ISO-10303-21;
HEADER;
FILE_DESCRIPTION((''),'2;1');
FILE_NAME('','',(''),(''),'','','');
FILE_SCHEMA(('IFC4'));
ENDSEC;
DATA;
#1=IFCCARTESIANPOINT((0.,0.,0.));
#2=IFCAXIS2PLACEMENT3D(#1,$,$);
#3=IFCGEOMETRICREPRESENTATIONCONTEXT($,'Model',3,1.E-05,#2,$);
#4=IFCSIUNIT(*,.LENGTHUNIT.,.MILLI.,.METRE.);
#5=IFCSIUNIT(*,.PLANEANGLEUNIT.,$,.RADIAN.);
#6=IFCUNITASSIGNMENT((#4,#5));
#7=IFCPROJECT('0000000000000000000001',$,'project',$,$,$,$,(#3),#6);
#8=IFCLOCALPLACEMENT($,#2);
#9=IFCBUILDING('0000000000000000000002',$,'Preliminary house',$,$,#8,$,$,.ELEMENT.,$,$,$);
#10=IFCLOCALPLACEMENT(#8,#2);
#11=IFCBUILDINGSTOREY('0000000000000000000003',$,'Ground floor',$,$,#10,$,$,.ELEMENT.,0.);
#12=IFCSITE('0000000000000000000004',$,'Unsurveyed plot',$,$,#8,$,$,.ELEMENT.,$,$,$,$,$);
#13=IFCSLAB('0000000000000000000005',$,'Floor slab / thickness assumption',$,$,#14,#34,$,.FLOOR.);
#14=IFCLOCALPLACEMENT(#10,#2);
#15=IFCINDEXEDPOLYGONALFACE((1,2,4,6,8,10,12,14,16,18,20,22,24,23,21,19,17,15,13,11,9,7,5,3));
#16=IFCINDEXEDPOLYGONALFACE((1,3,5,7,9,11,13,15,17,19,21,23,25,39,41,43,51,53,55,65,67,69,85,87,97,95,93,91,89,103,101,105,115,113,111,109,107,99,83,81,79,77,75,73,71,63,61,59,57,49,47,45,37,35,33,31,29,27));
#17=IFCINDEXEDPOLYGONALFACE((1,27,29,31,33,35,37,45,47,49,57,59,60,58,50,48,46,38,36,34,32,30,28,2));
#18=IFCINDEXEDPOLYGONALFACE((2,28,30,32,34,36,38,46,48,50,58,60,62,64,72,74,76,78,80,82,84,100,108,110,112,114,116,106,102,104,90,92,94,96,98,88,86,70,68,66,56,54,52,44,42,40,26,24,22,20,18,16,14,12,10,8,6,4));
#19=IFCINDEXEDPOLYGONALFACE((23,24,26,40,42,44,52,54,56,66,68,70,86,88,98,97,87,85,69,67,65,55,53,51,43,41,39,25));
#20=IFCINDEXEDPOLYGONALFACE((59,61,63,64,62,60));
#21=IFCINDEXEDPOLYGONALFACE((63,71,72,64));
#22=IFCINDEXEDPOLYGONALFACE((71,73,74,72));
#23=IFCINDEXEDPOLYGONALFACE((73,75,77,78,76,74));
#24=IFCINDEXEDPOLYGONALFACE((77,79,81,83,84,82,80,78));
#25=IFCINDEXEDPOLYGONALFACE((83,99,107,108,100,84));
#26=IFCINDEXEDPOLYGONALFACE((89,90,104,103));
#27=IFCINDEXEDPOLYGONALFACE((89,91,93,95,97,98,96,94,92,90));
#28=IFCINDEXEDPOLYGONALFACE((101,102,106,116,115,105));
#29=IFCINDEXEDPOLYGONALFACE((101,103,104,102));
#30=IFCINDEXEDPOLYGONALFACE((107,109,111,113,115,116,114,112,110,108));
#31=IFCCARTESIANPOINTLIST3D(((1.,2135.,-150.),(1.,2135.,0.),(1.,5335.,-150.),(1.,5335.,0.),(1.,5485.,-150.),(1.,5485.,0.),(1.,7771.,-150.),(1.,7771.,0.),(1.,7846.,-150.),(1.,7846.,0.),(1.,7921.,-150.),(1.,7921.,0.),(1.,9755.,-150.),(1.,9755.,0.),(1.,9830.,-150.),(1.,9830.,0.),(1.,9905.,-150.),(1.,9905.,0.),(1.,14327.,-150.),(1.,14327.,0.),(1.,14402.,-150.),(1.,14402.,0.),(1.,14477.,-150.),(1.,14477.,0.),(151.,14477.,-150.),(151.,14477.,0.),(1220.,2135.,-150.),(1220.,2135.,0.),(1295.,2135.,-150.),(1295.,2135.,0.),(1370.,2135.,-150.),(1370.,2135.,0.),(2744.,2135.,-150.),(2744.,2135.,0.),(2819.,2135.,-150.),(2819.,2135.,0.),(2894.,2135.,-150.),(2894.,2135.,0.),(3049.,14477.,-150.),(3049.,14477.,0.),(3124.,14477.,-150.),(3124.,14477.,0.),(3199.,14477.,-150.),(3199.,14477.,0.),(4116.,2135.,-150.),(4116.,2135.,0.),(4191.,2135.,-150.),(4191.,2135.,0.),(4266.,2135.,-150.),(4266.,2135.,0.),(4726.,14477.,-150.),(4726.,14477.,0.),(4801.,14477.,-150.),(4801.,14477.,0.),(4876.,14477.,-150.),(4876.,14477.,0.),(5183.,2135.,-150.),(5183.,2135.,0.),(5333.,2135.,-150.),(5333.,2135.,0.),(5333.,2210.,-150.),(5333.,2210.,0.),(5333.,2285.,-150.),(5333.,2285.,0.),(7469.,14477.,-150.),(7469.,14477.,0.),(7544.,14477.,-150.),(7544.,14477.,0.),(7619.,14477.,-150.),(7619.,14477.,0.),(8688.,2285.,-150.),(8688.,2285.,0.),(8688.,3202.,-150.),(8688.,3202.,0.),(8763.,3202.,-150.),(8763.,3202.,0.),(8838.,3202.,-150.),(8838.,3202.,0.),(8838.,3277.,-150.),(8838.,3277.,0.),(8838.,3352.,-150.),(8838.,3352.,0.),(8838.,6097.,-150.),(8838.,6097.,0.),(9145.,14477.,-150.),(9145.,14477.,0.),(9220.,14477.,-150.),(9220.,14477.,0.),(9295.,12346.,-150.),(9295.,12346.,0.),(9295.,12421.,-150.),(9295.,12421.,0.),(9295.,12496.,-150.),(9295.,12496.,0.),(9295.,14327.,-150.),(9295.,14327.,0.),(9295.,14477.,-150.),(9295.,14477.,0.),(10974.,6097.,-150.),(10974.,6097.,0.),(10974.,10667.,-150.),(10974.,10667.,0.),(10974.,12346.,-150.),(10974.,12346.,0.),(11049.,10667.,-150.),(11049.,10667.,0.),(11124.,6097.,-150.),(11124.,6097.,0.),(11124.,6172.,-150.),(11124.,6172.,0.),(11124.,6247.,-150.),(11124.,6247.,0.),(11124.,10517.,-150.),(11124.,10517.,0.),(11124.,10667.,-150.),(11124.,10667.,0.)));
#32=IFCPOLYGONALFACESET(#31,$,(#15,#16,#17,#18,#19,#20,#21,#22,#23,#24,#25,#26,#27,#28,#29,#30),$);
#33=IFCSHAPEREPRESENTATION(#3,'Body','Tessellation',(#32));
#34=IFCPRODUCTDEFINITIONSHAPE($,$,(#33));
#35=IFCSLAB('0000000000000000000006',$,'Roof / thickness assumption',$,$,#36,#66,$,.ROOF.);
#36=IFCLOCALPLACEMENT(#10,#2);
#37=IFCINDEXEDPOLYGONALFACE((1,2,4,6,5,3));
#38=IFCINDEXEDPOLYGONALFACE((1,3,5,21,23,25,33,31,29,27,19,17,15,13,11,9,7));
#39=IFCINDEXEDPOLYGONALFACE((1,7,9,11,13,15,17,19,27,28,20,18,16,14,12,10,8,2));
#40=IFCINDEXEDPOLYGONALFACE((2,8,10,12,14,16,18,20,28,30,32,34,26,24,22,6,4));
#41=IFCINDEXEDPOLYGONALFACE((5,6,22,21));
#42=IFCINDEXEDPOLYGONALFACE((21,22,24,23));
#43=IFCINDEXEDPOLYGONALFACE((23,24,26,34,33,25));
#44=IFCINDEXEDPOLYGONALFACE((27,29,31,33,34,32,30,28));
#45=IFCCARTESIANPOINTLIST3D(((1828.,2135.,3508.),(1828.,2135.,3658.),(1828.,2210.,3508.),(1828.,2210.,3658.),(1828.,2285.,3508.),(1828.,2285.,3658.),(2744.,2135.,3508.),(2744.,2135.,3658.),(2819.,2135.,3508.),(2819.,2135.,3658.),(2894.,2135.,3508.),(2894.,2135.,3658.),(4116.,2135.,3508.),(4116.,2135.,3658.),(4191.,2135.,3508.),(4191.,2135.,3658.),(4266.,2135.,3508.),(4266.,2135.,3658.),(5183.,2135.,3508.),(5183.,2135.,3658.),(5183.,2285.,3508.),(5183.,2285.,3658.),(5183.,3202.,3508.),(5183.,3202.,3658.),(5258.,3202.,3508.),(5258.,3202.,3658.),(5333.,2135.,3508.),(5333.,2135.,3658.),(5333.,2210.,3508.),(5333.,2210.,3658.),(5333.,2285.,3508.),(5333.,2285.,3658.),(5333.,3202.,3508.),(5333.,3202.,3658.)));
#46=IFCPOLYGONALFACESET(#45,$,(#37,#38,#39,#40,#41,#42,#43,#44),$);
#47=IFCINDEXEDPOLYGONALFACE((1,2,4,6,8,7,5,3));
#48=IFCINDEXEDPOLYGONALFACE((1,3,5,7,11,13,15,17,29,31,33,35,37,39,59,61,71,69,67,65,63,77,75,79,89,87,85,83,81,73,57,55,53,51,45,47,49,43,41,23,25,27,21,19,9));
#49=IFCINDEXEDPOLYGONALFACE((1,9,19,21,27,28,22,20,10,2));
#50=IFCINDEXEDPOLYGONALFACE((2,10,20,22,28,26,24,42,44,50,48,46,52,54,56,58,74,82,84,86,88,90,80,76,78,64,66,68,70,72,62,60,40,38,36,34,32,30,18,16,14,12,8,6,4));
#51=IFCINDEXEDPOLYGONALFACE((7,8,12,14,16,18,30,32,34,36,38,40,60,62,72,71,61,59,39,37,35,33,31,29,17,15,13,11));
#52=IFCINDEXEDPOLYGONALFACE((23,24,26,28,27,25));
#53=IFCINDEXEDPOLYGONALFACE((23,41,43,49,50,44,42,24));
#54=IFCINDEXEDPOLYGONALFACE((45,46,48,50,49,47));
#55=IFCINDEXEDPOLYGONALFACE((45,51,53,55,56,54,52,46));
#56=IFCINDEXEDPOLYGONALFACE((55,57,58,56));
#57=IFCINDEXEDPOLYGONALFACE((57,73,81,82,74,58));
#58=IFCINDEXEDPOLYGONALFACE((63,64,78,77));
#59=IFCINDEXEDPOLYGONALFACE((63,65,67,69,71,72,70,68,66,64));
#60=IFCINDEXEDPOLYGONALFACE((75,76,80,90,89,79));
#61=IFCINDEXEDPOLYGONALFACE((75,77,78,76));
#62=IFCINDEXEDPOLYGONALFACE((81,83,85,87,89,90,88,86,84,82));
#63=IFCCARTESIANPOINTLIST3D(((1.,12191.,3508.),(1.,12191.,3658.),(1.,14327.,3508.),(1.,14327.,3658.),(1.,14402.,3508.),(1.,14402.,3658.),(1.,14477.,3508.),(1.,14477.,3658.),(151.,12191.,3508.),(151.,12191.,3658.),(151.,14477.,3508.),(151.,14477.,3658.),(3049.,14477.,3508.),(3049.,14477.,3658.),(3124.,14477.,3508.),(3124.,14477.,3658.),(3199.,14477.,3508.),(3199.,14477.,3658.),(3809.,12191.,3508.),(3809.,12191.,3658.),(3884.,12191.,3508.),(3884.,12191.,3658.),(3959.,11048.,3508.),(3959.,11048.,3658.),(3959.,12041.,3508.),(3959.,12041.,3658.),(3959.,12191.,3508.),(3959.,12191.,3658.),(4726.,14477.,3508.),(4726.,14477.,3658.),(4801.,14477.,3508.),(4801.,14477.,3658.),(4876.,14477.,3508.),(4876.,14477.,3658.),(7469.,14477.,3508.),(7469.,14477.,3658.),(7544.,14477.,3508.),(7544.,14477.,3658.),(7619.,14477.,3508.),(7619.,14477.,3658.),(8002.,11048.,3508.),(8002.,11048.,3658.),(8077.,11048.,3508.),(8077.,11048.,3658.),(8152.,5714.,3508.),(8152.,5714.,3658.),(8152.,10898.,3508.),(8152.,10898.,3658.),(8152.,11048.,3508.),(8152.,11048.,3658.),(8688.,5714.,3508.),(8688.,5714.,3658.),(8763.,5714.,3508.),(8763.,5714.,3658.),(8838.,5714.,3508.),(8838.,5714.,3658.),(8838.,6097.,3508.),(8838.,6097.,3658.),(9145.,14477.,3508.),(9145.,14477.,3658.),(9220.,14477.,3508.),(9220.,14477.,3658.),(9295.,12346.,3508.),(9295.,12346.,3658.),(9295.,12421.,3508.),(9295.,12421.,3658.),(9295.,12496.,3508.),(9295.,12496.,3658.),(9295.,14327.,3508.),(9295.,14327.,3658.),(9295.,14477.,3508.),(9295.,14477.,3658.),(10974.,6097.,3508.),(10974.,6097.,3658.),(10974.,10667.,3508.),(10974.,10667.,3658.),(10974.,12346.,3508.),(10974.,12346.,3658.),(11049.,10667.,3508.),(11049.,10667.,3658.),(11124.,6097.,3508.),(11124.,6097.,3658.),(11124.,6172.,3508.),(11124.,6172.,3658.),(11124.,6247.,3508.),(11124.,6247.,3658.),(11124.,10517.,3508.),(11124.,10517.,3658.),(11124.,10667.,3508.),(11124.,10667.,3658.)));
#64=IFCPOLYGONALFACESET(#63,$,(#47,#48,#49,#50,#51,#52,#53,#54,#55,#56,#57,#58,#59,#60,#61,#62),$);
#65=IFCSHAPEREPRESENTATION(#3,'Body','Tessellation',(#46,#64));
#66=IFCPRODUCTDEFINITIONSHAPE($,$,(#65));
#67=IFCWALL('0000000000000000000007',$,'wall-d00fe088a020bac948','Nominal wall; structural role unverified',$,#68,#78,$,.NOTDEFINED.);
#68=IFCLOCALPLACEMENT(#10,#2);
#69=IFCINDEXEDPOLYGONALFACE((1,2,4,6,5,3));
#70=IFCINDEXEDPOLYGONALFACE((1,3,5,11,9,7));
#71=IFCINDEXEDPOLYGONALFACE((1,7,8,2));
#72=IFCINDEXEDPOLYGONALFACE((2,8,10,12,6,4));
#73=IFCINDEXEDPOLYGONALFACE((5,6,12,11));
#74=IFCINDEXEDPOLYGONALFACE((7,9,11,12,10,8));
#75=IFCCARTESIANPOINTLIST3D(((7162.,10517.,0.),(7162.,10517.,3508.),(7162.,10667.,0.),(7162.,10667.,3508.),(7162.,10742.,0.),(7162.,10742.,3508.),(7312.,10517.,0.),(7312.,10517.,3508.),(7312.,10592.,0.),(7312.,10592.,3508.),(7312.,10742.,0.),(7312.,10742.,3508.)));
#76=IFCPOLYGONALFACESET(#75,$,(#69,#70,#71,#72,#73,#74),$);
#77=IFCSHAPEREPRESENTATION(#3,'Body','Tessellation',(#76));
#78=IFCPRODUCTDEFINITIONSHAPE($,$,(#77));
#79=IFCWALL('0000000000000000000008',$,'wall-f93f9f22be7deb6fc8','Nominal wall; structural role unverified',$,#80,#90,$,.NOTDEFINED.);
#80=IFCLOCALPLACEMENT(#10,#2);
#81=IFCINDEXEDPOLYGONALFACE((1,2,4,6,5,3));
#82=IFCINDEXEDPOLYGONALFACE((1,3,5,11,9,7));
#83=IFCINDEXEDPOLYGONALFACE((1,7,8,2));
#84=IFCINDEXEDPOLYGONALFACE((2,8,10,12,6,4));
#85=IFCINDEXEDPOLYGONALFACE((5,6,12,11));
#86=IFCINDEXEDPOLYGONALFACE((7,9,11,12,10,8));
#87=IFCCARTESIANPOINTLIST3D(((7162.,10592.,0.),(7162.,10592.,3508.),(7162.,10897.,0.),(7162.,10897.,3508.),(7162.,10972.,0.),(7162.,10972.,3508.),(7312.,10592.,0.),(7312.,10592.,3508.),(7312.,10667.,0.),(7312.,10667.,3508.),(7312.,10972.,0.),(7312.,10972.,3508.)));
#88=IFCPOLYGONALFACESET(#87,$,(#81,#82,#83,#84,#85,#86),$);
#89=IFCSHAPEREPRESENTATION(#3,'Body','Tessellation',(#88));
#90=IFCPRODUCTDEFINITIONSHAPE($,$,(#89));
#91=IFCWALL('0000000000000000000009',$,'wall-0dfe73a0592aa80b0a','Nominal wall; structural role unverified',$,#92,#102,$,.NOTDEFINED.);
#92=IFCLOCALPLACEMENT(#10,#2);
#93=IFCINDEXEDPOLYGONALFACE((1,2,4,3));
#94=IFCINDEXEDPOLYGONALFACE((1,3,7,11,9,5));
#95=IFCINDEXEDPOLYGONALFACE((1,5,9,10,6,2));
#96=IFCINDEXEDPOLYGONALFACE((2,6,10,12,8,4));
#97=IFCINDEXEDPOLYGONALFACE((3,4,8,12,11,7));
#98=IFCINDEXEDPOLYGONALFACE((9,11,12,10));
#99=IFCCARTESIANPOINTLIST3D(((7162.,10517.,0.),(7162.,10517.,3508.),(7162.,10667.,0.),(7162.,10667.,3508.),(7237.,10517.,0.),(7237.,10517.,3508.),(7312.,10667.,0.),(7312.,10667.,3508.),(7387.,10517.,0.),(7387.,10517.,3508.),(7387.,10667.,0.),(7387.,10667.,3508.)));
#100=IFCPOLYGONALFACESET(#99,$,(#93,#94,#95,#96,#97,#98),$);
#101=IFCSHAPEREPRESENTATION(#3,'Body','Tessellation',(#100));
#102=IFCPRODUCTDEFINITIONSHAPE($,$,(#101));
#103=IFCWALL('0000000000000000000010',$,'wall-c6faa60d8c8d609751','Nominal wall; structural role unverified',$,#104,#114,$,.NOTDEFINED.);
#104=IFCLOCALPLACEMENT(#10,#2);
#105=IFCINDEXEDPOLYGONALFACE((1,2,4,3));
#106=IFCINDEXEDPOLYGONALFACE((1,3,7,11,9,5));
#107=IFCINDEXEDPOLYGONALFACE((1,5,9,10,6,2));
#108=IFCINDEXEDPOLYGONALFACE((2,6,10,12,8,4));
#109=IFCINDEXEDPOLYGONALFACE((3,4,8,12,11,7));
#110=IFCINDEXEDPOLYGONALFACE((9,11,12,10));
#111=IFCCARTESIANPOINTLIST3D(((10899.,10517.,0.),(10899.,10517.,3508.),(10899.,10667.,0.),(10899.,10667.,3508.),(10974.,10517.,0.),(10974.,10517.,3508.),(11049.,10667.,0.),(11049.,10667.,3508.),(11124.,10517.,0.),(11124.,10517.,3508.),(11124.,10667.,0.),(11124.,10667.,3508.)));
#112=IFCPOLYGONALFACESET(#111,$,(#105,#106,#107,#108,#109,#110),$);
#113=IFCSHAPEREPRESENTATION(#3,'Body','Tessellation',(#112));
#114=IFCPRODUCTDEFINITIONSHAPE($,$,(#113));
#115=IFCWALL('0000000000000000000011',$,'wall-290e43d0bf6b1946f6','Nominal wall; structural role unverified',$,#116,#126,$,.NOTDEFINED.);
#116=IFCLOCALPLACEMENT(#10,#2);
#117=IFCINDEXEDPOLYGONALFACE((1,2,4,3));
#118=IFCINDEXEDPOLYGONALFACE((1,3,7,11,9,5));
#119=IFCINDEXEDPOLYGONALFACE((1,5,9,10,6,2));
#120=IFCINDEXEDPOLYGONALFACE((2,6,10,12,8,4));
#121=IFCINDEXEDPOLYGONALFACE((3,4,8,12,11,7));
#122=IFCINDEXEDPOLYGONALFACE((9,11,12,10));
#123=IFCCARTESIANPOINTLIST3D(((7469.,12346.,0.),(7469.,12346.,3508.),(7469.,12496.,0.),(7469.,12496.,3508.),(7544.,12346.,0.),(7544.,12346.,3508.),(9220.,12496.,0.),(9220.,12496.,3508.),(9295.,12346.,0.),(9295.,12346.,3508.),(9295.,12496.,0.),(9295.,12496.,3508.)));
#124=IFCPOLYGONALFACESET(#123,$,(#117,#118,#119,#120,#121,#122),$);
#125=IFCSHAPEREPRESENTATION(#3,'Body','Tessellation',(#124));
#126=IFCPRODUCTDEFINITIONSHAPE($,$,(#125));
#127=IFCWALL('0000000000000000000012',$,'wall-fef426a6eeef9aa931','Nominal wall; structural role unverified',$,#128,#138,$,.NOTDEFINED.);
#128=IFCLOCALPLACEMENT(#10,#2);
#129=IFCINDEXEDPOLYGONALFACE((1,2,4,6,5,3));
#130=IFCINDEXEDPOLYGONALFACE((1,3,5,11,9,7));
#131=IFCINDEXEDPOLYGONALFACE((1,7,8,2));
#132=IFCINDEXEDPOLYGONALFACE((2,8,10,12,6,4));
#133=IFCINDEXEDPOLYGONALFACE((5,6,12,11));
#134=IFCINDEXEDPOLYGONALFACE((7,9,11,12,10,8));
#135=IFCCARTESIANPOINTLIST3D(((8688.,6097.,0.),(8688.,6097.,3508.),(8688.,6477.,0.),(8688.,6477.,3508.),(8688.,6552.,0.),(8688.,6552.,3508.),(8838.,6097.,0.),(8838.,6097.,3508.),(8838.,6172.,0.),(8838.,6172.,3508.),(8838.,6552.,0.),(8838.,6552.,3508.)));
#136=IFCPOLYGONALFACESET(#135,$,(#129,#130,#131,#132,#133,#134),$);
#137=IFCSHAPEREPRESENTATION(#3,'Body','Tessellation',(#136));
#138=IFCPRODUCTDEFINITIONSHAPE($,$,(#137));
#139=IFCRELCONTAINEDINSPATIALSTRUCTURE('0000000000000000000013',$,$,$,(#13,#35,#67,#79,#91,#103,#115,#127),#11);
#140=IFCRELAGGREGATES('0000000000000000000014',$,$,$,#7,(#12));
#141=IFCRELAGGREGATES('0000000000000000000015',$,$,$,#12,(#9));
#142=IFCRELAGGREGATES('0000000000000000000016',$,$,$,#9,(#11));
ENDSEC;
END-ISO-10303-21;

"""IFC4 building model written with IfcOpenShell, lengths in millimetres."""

from ifc_helpers import new_model, si_unit, frame, origin, place, context, project, spatial, polyline, outline, extrude, element, save


model = new_model("IFC4")

# Units and contexts
model_context = context("Model", 3, precision=1e-05, world=origin())
ifc_project = project(units=[si_unit("LENGTHUNIT", "METRE", prefix="MILLI"), si_unit("PLANEANGLEUNIT", "RADIAN")], contexts=[model_context])

# Site, building, storey
placement_1 = place(None, origin())
site = spatial("IfcSite", under=ifc_project, at=placement_1, Name="Unsurveyed plot", CompositionType="ELEMENT")
building = spatial("IfcBuilding", under=site, at=placement_1, Name="Preliminary house", CompositionType="ELEMENT")
placement_2 = place(placement_1, origin())
storey = spatial("IfcBuildingStorey", under=building, at=placement_2, Name="Ground floor", CompositionType="ELEMENT", Elevation=0.0)

# Slabs
element("IfcSlab", 1, at=placement_2, inside=storey, Name="Floor slab / thickness assumption", PredefinedType="FLOOR", context=model_context, shape_type="SweptSolid", body=[
    extrude(outline(polyline([(1370.0, 2135.0), (1295.0, 2135.0), (1220.0, 2135.0), (1.0, 2135.0), (1.0, 5335.0), (1.0, 5485.0), (1.0, 7771.0), (1.0, 7846.0), (1.0, 7921.0), (1.0, 9755.0), (1.0, 9830.0), (1.0, 9905.0), (1.0, 14327.0), (1.0, 14402.0), (1.0, 14477.0), (151.0, 14477.0), (3049.0, 14477.0), (3124.0, 14477.0), (3199.0, 14477.0), (4726.0, 14477.0), (4801.0, 14477.0), (4876.0, 14477.0), (7469.0, 14477.0), (7544.0, 14477.0), (7619.0, 14477.0), (9145.0, 14477.0), (9220.0, 14477.0), (9295.0, 14477.0), (9295.0, 14327.0), (9295.0, 12496.0), (9295.0, 12421.0), (9295.0, 12346.0), (10974.0, 12346.0), (10974.0, 10667.0), (11049.0, 10667.0), (11124.0, 10667.0), (11124.0, 10517.0), (11124.0, 6247.0), (11124.0, 6172.0), (11124.0, 6097.0), (10974.0, 6097.0), (8838.0, 6097.0), (8838.0, 3352.0), (8838.0, 3277.0), (8838.0, 3202.0), (8763.0, 3202.0), (8688.0, 3202.0), (8688.0, 2285.0), (5333.0, 2285.0), (5333.0, 2210.0), (5333.0, 2135.0), (5183.0, 2135.0), (4266.0, 2135.0), (4191.0, 2135.0), (4116.0, 2135.0), (2894.0, 2135.0), (2819.0, 2135.0), (2744.0, 2135.0), (1370.0, 2135.0)])), frame((0.0, 0.0, -150.0)), (0.0, 0.0, 1.0), 150.0),
])
element("IfcSlab", 2, at=placement_2, inside=storey, Name="Roof / thickness assumption", PredefinedType="ROOF", context=model_context, shape_type="SweptSolid", body=[
    extrude(outline(polyline([(5333.0, 2210.0), (5333.0, 2135.0), (5183.0, 2135.0), (4266.0, 2135.0), (4191.0, 2135.0), (4116.0, 2135.0), (2894.0, 2135.0), (2819.0, 2135.0), (2744.0, 2135.0), (1828.0, 2135.0), (1828.0, 2210.0), (1828.0, 2285.0), (5183.0, 2285.0), (5183.0, 3202.0), (5258.0, 3202.0), (5333.0, 3202.0), (5333.0, 2285.0), (5333.0, 2210.0)])), frame((0.0, 0.0, 3508.0)), (0.0, 0.0, 1.0), 150.0),
    extrude(outline(polyline([(1.0, 14402.0), (1.0, 14477.0), (151.0, 14477.0), (3049.0, 14477.0), (3124.0, 14477.0), (3199.0, 14477.0), (4726.0, 14477.0), (4801.0, 14477.0), (4876.0, 14477.0), (7469.0, 14477.0), (7544.0, 14477.0), (7619.0, 14477.0), (9145.0, 14477.0), (9220.0, 14477.0), (9295.0, 14477.0), (9295.0, 14327.0), (9295.0, 12496.0), (9295.0, 12421.0), (9295.0, 12346.0), (10974.0, 12346.0), (10974.0, 10667.0), (11049.0, 10667.0), (11124.0, 10667.0), (11124.0, 10517.0), (11124.0, 6247.0), (11124.0, 6172.0), (11124.0, 6097.0), (10974.0, 6097.0), (8838.0, 6097.0), (8838.0, 5714.0), (8763.0, 5714.0), (8688.0, 5714.0), (8152.0, 5714.0), (8152.0, 10898.0), (8152.0, 11048.0), (8077.0, 11048.0), (8002.0, 11048.0), (3959.0, 11048.0), (3959.0, 12041.0), (3959.0, 12191.0), (3884.0, 12191.0), (3809.0, 12191.0), (151.0, 12191.0), (1.0, 12191.0), (1.0, 14327.0), (1.0, 14402.0)])), frame((0.0, 0.0, 3508.0)), (0.0, 0.0, 1.0), 150.0),
])

# Walls
element("IfcWall", 3, at=placement_2, inside=storey, Name="wall-d00fe088a020bac948", Description="Nominal wall; structural role unverified", PredefinedType="NOTDEFINED", context=model_context, shape_type="SweptSolid", body=[
    extrude(outline(polyline([(7162.0, 10667.0), (7162.0, 10742.0), (7312.0, 10742.0), (7312.0, 10592.0), (7312.0, 10517.0), (7162.0, 10517.0), (7162.0, 10667.0)])), origin(), (0.0, 0.0, 1.0), 3508.0),
])
element("IfcWall", 4, at=placement_2, inside=storey, Name="wall-f93f9f22be7deb6fc8", Description="Nominal wall; structural role unverified", PredefinedType="NOTDEFINED", context=model_context, shape_type="SweptSolid", body=[
    extrude(outline(polyline([(7162.0, 10897.0), (7162.0, 10972.0), (7312.0, 10972.0), (7312.0, 10667.0), (7312.0, 10592.0), (7162.0, 10592.0), (7162.0, 10897.0)])), origin(), (0.0, 0.0, 1.0), 3508.0),
])
element("IfcWall", 5, at=placement_2, inside=storey, Name="wall-0dfe73a0592aa80b0a", Description="Nominal wall; structural role unverified", PredefinedType="NOTDEFINED", context=model_context, shape_type="SweptSolid", body=[
    extrude(outline(polyline([(7312.0, 10667.0), (7387.0, 10667.0), (7387.0, 10517.0), (7237.0, 10517.0), (7162.0, 10517.0), (7162.0, 10667.0), (7312.0, 10667.0)])), origin(), (0.0, 0.0, 1.0), 3508.0),
])

# Wall
element("IfcWall", 6, at=placement_2, inside=storey, Name="wall-c6faa60d8c8d609751", Description="Nominal wall; structural role unverified", PredefinedType="NOTDEFINED", context=model_context, shape_type="SweptSolid", body=[
    extrude(outline(polyline([(11049.0, 10667.0), (11124.0, 10667.0), (11124.0, 10517.0), (10974.0, 10517.0), (10899.0, 10517.0), (10899.0, 10667.0), (11049.0, 10667.0)])), origin(), (0.0, 0.0, 1.0), 3508.0),
])

# Wall
element("IfcWall", 7, at=placement_2, inside=storey, Name="wall-290e43d0bf6b1946f6", Description="Nominal wall; structural role unverified", PredefinedType="NOTDEFINED", context=model_context, shape_type="SweptSolid", body=[
    extrude(outline(polyline([(9220.0, 12496.0), (9295.0, 12496.0), (9295.0, 12346.0), (7544.0, 12346.0), (7469.0, 12346.0), (7469.0, 12496.0), (9220.0, 12496.0)])), origin(), (0.0, 0.0, 1.0), 3508.0),
])

# Wall
element("IfcWall", 8, at=placement_2, inside=storey, Name="wall-fef426a6eeef9aa931", Description="Nominal wall; structural role unverified", PredefinedType="NOTDEFINED", context=model_context, shape_type="SweptSolid", body=[
    extrude(outline(polyline([(8688.0, 6477.0), (8688.0, 6552.0), (8838.0, 6552.0), (8838.0, 6172.0), (8838.0, 6097.0), (8688.0, 6097.0), (8688.0, 6477.0)])), origin(), (0.0, 0.0, 1.0), 3508.0),
])

save(model, "model.ifc")
